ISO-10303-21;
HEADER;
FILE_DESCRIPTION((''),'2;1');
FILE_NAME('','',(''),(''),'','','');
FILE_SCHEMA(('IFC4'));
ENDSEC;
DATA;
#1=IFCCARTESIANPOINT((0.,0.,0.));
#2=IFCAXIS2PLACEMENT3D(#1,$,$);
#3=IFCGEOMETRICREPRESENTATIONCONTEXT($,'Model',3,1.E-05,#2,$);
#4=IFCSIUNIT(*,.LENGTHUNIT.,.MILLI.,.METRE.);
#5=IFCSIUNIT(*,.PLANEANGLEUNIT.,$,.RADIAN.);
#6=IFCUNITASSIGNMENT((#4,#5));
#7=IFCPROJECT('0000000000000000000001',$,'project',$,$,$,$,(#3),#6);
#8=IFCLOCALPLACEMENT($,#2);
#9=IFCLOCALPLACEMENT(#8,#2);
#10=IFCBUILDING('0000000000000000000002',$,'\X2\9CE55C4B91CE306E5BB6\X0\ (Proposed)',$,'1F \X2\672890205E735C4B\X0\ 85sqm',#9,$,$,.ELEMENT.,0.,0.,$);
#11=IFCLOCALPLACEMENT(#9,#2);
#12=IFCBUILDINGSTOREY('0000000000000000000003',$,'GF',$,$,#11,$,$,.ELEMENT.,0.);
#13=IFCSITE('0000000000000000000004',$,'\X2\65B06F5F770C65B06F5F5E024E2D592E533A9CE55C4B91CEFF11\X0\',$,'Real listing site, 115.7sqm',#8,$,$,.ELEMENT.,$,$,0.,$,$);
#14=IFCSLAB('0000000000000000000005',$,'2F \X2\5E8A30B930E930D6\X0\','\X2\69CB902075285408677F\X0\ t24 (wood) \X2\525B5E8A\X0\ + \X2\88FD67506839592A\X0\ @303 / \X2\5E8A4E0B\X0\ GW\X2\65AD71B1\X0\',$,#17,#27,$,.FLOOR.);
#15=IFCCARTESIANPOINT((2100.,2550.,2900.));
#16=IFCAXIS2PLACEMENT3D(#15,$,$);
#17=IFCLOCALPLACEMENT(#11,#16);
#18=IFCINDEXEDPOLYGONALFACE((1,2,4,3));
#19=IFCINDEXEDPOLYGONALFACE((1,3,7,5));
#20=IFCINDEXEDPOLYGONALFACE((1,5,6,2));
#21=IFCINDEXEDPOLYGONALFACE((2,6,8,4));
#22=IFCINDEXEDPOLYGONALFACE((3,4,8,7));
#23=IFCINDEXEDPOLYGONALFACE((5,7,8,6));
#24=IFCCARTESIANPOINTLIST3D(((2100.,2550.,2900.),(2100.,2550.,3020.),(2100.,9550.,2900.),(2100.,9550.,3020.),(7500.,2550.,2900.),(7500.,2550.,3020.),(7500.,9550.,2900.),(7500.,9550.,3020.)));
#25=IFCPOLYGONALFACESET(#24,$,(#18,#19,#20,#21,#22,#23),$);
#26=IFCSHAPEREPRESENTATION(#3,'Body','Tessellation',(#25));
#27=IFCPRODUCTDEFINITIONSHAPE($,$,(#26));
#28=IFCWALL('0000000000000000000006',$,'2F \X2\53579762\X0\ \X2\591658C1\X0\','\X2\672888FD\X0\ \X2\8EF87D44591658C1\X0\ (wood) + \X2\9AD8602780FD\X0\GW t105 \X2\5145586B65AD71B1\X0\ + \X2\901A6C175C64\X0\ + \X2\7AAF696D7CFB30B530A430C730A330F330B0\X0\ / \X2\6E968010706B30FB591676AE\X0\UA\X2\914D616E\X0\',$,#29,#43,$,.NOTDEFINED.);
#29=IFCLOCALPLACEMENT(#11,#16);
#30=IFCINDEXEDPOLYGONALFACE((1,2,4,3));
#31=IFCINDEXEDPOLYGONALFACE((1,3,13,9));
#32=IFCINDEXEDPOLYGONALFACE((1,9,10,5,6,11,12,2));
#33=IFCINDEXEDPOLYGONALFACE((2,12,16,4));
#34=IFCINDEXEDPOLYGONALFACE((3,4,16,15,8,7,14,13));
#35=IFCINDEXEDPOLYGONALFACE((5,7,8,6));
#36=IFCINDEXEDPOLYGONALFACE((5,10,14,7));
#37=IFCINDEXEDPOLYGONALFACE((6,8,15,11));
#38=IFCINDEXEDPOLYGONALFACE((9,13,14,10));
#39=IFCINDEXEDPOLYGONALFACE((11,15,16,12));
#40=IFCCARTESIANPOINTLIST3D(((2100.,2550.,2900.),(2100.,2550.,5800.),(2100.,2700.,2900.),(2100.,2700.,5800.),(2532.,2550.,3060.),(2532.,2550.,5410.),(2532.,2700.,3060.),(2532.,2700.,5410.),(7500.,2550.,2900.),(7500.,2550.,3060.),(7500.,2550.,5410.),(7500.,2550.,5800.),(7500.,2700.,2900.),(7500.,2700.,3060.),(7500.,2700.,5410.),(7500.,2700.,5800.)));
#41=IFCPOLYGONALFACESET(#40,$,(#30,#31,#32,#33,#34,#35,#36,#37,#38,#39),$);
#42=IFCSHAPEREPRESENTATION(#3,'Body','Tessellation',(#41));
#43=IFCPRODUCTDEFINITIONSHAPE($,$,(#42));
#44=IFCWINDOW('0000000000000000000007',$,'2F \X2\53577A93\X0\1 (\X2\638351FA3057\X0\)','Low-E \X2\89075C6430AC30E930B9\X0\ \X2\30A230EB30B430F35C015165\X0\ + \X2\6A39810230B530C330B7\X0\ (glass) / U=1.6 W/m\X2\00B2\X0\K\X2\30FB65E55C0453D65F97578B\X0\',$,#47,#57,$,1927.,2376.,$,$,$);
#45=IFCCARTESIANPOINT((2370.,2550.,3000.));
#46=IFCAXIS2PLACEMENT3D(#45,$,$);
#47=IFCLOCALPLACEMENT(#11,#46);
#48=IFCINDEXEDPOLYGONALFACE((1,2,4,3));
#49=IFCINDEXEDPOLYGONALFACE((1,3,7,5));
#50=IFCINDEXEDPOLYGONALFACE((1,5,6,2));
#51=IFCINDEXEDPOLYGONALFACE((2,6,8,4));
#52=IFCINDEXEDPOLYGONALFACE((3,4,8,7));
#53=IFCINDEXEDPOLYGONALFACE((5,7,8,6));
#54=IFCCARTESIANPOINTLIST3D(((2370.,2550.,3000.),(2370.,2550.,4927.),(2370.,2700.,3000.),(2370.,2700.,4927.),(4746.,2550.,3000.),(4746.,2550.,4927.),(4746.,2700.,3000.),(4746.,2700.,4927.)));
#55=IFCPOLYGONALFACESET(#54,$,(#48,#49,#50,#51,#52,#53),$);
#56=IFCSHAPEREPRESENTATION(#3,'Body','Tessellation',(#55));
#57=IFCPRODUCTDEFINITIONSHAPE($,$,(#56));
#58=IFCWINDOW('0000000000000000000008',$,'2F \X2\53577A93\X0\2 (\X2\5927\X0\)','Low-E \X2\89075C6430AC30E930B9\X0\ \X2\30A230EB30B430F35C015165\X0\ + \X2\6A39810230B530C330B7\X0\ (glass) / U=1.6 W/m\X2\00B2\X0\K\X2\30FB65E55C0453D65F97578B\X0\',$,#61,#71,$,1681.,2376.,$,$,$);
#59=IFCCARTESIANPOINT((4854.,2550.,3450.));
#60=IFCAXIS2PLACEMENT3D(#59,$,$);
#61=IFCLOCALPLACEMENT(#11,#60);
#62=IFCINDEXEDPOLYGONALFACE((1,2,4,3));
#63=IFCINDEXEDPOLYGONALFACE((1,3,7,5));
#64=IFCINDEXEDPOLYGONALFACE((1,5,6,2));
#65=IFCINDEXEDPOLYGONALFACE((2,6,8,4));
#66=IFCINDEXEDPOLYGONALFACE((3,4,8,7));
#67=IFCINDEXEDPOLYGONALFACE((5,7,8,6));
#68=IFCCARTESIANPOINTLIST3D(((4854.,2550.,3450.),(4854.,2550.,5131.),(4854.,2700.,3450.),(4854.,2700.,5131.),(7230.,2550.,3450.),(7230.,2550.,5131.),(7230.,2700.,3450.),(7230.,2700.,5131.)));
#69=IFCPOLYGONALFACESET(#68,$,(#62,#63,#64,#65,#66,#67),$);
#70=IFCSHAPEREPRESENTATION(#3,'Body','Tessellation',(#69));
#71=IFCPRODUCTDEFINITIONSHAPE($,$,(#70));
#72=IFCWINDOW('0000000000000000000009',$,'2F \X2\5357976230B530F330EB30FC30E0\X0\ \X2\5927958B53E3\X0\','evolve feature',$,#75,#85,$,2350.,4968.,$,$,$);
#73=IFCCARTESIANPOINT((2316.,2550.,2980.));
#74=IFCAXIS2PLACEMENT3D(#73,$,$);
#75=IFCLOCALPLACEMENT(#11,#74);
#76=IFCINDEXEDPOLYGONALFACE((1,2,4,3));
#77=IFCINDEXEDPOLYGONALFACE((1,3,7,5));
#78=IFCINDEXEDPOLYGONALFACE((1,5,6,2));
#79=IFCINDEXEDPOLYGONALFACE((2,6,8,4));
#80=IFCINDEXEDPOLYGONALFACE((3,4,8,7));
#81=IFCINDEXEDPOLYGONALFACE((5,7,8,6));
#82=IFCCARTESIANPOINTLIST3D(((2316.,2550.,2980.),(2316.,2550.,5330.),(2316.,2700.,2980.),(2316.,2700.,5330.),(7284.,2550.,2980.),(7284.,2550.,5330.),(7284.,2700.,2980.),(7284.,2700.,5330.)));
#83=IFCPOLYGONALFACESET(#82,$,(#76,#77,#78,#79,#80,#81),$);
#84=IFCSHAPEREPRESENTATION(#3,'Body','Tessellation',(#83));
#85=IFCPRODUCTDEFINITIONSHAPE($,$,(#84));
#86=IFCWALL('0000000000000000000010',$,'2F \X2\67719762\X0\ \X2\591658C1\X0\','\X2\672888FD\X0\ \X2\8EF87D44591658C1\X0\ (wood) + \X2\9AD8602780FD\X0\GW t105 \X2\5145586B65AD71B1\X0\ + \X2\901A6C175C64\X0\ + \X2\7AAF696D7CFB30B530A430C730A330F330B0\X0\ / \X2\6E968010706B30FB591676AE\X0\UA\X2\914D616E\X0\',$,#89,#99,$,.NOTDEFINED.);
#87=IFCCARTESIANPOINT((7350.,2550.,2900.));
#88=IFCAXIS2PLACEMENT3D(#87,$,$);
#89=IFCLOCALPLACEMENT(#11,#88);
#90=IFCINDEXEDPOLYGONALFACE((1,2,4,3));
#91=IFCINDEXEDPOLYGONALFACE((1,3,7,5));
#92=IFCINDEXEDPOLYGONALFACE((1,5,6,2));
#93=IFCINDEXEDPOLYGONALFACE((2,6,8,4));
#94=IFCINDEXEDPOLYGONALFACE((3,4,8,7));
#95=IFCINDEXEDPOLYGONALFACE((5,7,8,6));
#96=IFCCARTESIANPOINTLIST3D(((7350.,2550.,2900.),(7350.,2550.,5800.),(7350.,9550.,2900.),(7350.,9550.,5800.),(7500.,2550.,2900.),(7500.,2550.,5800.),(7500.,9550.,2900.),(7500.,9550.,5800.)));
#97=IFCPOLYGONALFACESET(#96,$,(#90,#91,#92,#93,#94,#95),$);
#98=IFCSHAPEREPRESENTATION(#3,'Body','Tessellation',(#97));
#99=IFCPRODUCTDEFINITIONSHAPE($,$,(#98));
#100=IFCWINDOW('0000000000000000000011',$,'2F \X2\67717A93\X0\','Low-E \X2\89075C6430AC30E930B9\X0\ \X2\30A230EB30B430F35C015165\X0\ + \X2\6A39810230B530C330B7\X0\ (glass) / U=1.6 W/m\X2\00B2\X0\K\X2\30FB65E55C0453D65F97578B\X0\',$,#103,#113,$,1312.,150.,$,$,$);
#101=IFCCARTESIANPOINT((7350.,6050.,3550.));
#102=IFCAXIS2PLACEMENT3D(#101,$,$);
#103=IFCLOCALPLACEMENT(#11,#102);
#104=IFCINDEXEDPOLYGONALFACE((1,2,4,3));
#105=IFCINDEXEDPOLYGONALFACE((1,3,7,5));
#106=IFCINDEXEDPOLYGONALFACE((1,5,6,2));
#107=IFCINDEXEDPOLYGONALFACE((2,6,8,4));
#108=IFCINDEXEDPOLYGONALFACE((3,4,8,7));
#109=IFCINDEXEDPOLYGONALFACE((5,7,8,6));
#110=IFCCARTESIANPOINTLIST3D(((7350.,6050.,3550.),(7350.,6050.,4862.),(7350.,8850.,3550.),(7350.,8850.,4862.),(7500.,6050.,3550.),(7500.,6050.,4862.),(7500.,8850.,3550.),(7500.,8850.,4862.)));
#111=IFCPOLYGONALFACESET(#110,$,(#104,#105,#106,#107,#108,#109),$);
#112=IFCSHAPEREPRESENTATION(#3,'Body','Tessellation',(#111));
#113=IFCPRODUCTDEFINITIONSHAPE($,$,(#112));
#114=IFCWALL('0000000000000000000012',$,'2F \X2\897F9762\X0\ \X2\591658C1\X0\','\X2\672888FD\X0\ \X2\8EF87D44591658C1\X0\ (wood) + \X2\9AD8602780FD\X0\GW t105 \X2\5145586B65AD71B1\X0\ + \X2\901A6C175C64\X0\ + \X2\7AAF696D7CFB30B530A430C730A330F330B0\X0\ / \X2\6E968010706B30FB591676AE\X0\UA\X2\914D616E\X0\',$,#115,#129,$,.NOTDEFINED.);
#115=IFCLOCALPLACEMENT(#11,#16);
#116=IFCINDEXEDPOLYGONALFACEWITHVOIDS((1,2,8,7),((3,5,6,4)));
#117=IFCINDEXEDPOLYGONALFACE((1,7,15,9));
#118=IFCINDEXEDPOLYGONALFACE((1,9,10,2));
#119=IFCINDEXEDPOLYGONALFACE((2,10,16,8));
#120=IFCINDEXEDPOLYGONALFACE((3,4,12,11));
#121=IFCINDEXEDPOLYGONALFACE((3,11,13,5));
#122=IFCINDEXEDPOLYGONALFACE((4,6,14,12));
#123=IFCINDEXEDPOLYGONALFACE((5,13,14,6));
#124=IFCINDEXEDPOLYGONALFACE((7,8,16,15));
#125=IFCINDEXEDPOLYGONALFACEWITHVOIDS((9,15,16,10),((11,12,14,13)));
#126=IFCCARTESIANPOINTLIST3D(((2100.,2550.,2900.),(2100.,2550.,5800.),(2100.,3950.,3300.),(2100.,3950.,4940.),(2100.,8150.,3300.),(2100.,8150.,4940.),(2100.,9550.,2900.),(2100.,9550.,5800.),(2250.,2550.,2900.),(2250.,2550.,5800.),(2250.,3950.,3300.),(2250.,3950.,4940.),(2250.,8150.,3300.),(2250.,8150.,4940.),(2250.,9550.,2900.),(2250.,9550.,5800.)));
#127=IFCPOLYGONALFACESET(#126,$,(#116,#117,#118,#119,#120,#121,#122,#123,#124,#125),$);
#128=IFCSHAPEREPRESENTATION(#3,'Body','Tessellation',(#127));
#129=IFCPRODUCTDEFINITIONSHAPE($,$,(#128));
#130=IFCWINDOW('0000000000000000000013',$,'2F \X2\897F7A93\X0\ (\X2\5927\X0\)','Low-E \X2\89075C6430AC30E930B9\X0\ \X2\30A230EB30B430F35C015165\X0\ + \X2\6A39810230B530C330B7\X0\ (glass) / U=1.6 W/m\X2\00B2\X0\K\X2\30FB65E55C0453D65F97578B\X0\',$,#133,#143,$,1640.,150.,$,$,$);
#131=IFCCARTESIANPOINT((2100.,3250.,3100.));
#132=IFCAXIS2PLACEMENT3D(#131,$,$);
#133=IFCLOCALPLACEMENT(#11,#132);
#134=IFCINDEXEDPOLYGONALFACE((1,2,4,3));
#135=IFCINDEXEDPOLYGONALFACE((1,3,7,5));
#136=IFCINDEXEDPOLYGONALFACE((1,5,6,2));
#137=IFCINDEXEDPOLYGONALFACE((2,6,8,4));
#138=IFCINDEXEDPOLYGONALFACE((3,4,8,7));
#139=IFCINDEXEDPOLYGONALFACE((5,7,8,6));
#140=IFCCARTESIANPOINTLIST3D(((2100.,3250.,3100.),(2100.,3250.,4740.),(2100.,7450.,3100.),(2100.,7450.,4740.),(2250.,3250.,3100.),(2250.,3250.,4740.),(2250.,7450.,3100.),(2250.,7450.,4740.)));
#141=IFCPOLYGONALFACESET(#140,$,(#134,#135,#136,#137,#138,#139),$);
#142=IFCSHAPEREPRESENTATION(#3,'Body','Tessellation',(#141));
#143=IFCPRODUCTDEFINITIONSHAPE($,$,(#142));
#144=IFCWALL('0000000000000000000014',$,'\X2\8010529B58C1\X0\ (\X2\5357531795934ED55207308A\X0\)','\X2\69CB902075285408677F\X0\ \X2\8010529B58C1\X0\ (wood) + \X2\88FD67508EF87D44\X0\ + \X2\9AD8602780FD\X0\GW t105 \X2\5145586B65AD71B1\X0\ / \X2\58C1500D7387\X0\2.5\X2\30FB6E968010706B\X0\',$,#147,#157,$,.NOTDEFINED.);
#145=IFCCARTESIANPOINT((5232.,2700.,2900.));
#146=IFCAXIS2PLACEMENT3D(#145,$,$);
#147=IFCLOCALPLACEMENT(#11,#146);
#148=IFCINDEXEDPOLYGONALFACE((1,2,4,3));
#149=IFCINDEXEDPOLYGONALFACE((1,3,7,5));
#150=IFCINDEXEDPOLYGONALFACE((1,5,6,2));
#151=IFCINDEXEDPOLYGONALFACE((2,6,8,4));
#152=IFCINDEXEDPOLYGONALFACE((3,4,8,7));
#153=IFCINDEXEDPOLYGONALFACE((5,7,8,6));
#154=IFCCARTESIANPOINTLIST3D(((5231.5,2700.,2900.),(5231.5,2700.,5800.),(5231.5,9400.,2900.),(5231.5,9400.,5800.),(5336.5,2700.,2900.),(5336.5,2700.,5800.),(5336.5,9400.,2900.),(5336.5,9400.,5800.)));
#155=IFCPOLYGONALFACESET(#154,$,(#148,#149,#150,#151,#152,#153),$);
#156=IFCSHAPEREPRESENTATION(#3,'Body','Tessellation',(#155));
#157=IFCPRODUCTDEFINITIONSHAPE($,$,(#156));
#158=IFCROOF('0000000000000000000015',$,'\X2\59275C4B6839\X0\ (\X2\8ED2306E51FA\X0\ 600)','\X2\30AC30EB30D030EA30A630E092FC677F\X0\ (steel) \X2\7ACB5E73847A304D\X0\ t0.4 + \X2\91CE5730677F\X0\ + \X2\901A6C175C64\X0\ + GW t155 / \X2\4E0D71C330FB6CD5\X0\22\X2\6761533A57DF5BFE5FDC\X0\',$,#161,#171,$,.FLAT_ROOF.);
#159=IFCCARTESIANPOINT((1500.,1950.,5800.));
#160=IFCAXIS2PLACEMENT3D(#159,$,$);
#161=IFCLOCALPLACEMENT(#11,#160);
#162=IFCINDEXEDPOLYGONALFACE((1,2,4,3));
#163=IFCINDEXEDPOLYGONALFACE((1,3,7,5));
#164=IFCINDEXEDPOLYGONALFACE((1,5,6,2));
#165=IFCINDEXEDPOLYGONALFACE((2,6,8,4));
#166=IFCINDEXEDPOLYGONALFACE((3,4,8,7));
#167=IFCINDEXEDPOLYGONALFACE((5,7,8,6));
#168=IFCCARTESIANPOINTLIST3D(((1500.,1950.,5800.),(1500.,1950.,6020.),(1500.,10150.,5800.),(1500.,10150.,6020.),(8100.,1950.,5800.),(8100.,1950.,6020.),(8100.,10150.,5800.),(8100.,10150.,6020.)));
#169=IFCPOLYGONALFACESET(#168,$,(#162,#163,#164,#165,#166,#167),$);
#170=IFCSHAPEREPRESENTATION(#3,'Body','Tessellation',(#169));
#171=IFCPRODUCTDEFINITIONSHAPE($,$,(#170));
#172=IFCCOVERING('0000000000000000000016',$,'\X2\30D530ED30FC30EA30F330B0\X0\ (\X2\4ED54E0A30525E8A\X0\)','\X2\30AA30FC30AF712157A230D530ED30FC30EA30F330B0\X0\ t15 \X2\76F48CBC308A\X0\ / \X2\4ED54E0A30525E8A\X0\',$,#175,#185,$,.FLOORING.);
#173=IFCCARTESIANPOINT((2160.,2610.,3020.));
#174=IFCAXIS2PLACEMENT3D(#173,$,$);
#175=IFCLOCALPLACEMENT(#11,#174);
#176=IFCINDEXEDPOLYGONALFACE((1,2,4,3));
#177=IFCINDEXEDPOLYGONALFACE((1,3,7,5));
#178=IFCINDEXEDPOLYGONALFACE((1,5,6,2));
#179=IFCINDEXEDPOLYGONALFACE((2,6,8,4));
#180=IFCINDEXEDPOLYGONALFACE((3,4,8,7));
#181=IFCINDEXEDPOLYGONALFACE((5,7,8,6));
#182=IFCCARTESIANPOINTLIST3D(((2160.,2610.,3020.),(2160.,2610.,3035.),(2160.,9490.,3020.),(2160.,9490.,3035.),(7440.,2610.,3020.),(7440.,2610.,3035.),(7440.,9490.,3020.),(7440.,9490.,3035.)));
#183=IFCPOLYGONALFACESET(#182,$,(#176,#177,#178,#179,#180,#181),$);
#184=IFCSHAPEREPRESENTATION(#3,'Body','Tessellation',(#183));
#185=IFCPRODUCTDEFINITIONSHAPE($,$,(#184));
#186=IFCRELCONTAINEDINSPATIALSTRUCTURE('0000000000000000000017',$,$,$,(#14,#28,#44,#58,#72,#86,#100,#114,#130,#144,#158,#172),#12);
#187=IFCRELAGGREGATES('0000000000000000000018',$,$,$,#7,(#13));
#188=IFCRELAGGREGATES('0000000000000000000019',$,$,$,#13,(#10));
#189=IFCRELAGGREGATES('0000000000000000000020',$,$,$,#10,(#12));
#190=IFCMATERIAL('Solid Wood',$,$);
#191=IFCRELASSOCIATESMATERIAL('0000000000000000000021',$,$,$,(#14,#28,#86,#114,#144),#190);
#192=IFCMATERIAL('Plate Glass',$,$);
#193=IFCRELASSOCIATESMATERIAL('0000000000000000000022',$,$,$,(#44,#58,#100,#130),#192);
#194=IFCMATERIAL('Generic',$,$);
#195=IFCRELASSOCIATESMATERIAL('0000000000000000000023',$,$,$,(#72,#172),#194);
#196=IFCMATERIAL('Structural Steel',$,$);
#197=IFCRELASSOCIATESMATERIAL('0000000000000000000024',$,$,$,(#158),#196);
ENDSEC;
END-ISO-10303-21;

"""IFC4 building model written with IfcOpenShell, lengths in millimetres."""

from ifc_helpers import new_model, si_unit, frame, frame_2d, origin, place, context, project, spatial, rectangle, extrude, material, element, fill, save


model = new_model("IFC4")

# Units and contexts
model_context = context("Model", 3, precision=1e-05, world=origin())
ifc_project = project(units=[si_unit("LENGTHUNIT", "METRE", prefix="MILLI"), si_unit("PLANEANGLEUNIT", "RADIAN")], contexts=[model_context])

# Site, building, storey
site_placement = place(None, origin())
site = spatial("IfcSite", under=ifc_project, at=site_placement, Name="新潟県新潟市中央区鳥屋野１", ObjectType="Real listing site, 115.7sqm", CompositionType="ELEMENT", RefElevation=0.0)
building_placement = place(site_placement, origin())
building = spatial("IfcBuilding", under=site, at=building_placement, Name="鳥屋野の家 (Proposed)", ObjectType="1F 木造平屋 85sqm", CompositionType="ELEMENT", ElevationOfRefHeight=0.0, ElevationOfTerrain=0.0)
storey_placement = place(building_placement, origin())
storey = spatial("IfcBuildingStorey", under=building, at=storey_placement, Name="GF", CompositionType="ELEMENT", Elevation=0.0)

# Slab
ifc_material_1 = material(Name="Solid Wood")
slab_placement = place(storey_placement, frame((2100.0, 2550.0, 2900.0)))
element("IfcSlab", 1, at=slab_placement, inside=storey, material=ifc_material_1, Name="2F 床スラブ", Description="構造用合板 t24 (wood) 剛床 + 製材根太 @303 / 床下 GW断熱", PredefinedType="FLOOR", context=model_context, shape_type="SweptSolid", body=[
    extrude(rectangle(XDim=5400.0, YDim=7000.0, at=frame_2d((2700.0, 3500.0))), frame((2100.0, 2550.0, 2900.0)), (0.0, 0.0, 1.0), 120.0),
])

# Wall, openings, windows
wall_1_placement = place(storey_placement, frame((2100.0, 2550.0, 2900.0)))
wall_1 = element("IfcWall", 2, at=wall_1_placement, inside=storey, material=ifc_material_1, Name="2F 南面 外壁", Description="木製 軸組外壁 (wood) + 高性能GW t105 充填断熱 + 通気層 + 窯業系サイディング / 準耐火・外皮UA配慮", PredefinedType="NOTDEFINED", context=model_context, shape_type="SweptSolid", body=[
    extrude(rectangle(XDim=5400.0, YDim=150.0, at=frame_2d((2700.0, 75.0))), frame((2100.0, 2550.0, 2900.0)), (0.0, 0.0, 1.0), 2900.0),
])
opening_1_placement = place(storey_placement, frame((2370.0, 2550.0, 3000.0)))
opening_1 = element("IfcOpeningElement", 3, at=opening_1_placement, cuts=wall_1, PredefinedType="NOTDEFINED", context=model_context, shape_type="SweptSolid", body=[
    extrude(rectangle(XDim=2376.0, YDim=150.0, at=frame_2d((1188.0, 75.0))), frame((2370.0, 2550.0, 3000.0)), (0.0, 0.0, 1.0), 1927.0),
])
opening_2_placement = place(storey_placement, frame((4854.0, 2550.0, 3450.0)))
opening_2 = element("IfcOpeningElement", 4, at=opening_2_placement, cuts=wall_1, PredefinedType="NOTDEFINED", context=model_context, shape_type="SweptSolid", body=[
    extrude(rectangle(XDim=2376.0, YDim=150.0, at=frame_2d((1188.0, 75.0))), frame((4854.0, 2550.0, 3450.0)), (0.0, 0.0, 1.0), 1681.0),
])
opening_3_placement = place(storey_placement, frame((2316.0, 2550.0, 2980.0)))
opening_3 = element("IfcOpeningElement", 5, at=opening_3_placement, cuts=wall_1, PredefinedType="NOTDEFINED", context=model_context, shape_type="SweptSolid", body=[
    extrude(rectangle(XDim=4968.0, YDim=150.0, at=frame_2d((2484.0, 75.0))), frame((2316.0, 2550.0, 2980.0)), (0.0, 0.0, 1.0), 2350.0),
])
ifc_material_2 = material(Name="Plate Glass")
window_1_placement = place(storey_placement, frame((2370.0, 2550.0, 3000.0)))
window_1 = element("IfcWindow", 6, at=window_1_placement, inside=storey, material=ifc_material_2, Name="2F 南窓1 (掃出し)", Description="Low-E 複層ガラス アルゴン封入 + 樹脂サッシ (glass) / U=1.6 W/m²K・日射取得型", OverallHeight=1927.0, OverallWidth=2376.0, context=model_context, shape_type="SweptSolid", body=[
    extrude(rectangle(XDim=2376.0, YDim=150.0, at=frame_2d((1188.0, 75.0))), frame((2370.0, 2550.0, 3000.0)), (0.0, 0.0, 1.0), 1927.0),
])
fill(opening_1, window_1)
window_2_placement = place(storey_placement, frame((4854.0, 2550.0, 3450.0)))
window_2 = element("IfcWindow", 7, at=window_2_placement, inside=storey, material=ifc_material_2, Name="2F 南窓2 (大)", Description="Low-E 複層ガラス アルゴン封入 + 樹脂サッシ (glass) / U=1.6 W/m²K・日射取得型", OverallHeight=1681.0, OverallWidth=2376.0, context=model_context, shape_type="SweptSolid", body=[
    extrude(rectangle(XDim=2376.0, YDim=150.0, at=frame_2d((1188.0, 75.0))), frame((4854.0, 2550.0, 3450.0)), (0.0, 0.0, 1.0), 1681.0),
])
fill(opening_2, window_2)
ifc_material_3 = material(Name="Generic")
window_3_placement = place(storey_placement, frame((2316.0, 2550.0, 2980.0)))
window_3 = element("IfcWindow", 8, at=window_3_placement, inside=storey, material=ifc_material_3, Name="2F 南面サンルーム 大開口", Description="evolve feature", OverallHeight=2350.0, OverallWidth=4968.0, context=model_context, shape_type="SweptSolid", body=[
    extrude(rectangle(XDim=4968.0, YDim=150.0, at=frame_2d((2484.0, 75.0))), frame((2316.0, 2550.0, 2980.0)), (0.0, 0.0, 1.0), 2350.0),
])
fill(opening_3, window_3)

# Walls, openings, windows
wall_2_placement = place(storey_placement, frame((7350.0, 2550.0, 2900.0)))
wall_2 = element("IfcWall", 9, at=wall_2_placement, inside=storey, material=ifc_material_1, Name="2F 東面 外壁", Description="木製 軸組外壁 (wood) + 高性能GW t105 充填断熱 + 通気層 + 窯業系サイディング / 準耐火・外皮UA配慮", PredefinedType="NOTDEFINED", context=model_context, shape_type="SweptSolid", body=[
    extrude(rectangle(XDim=150.0, YDim=7000.0, at=frame_2d((75.0, 3500.0))), frame((7350.0, 2550.0, 2900.0)), (0.0, 0.0, 1.0), 2900.0),
])
opening_4_placement = place(storey_placement, frame((7350.0, 6050.0, 3550.0)))
opening_4 = element("IfcOpeningElement", 10, at=opening_4_placement, cuts=wall_2, PredefinedType="NOTDEFINED", context=model_context, shape_type="SweptSolid", body=[
    extrude(rectangle(XDim=150.0, YDim=2800.0, at=frame_2d((75.0, 1400.0))), frame((7350.0, 6050.0, 3550.0)), (0.0, 0.0, 1.0), 1312.0),
])
window_4_placement = place(storey_placement, frame((7350.0, 6050.0, 3550.0)))
window_4 = element("IfcWindow", 11, at=window_4_placement, inside=storey, material=ifc_material_2, Name="2F 東窓", Description="Low-E 複層ガラス アルゴン封入 + 樹脂サッシ (glass) / U=1.6 W/m²K・日射取得型", OverallHeight=1312.0, OverallWidth=150.0, context=model_context, shape_type="SweptSolid", body=[
    extrude(rectangle(XDim=150.0, YDim=2800.0, at=frame_2d((75.0, 1400.0))), frame((7350.0, 6050.0, 3550.0)), (0.0, 0.0, 1.0), 1312.0),
])
fill(opening_4, window_4)
wall_3_placement = place(storey_placement, frame((2100.0, 2550.0, 2900.0)))
wall_3 = element("IfcWall", 12, at=wall_3_placement, inside=storey, material=ifc_material_1, Name="2F 西面 外壁", Description="木製 軸組外壁 (wood) + 高性能GW t105 充填断熱 + 通気層 + 窯業系サイディング / 準耐火・外皮UA配慮", PredefinedType="NOTDEFINED", context=model_context, shape_type="SweptSolid", body=[
    extrude(rectangle(XDim=150.0, YDim=7000.0, at=frame_2d((75.0, 3500.0))), frame((2100.0, 2550.0, 2900.0)), (0.0, 0.0, 1.0), 2900.0),
])
opening_5_placement = place(storey_placement, frame((2100.0, 3250.0, 3100.0)))
opening_5 = element("IfcOpeningElement", 13, at=opening_5_placement, cuts=wall_3, PredefinedType="NOTDEFINED", context=model_context, shape_type="SweptSolid", body=[
    extrude(rectangle(XDim=150.0, YDim=4200.0, at=frame_2d((75.0, 2100.0))), frame((2100.0, 3250.0, 3100.0)), (0.0, 0.0, 1.0), 1640.0),
])
window_5_placement = place(storey_placement, frame((2100.0, 3250.0, 3100.0)))
window_5 = element("IfcWindow", 14, at=window_5_placement, inside=storey, material=ifc_material_2, Name="2F 西窓 (大)", Description="Low-E 複層ガラス アルゴン封入 + 樹脂サッシ (glass) / U=1.6 W/m²K・日射取得型", OverallHeight=1640.0, OverallWidth=150.0, context=model_context, shape_type="SweptSolid", body=[
    extrude(rectangle(XDim=150.0, YDim=4200.0, at=frame_2d((75.0, 2100.0))), frame((2100.0, 3250.0, 3100.0)), (0.0, 0.0, 1.0), 1640.0),
])
fill(opening_5, window_5)

# Wall
wall_4_placement = place(storey_placement, frame((5232.0, 2700.0, 2900.0)))
element("IfcWall", 15, at=wall_4_placement, inside=storey, material=ifc_material_1, Name="耐力壁 (南北間仕切り)", Description="構造用合板 耐力壁 (wood) + 製材軸組 + 高性能GW t105 充填断熱 / 壁倍率2.5・準耐火", PredefinedType="NOTDEFINED", context=model_context, shape_type="SweptSolid", body=[
    extrude(rectangle(XDim=105.0, YDim=6700.0, at=frame_2d((52.0, 3350.0))), frame((5232.0, 2700.0, 2900.0)), (0.0, 0.0, 1.0), 2900.0),
])

# Roof
ifc_material_4 = material(Name="Structural Steel")
roof_placement = place(storey_placement, frame((1500.0, 1950.0, 5800.0)))
element("IfcRoof", 16, at=roof_placement, inside=storey, material=ifc_material_4, Name="大屋根 (軒の出 600)", Description="ガルバリウム鋼板 (steel) 立平葺き t0.4 + 野地板 + 通気層 + GW t155 / 不燃・法22条区域対応", PredefinedType="FLAT_ROOF", context=model_context, shape_type="SweptSolid", body=[
    extrude(rectangle(XDim=6600.0, YDim=8200.0, at=frame_2d((3300.0, 4100.0))), frame((1500.0, 1950.0, 5800.0)), (0.0, 0.0, 1.0), 220.0),
])

# Covering
covering_placement = place(storey_placement, frame((2160.0, 2610.0, 3020.0)))
element("IfcCovering", 17, at=covering_placement, inside=storey, material=ifc_material_3, Name="フローリング (仕上げ床)", Description="オーク無垢フローリング t15 直貼り / 仕上げ床", PredefinedType="FLOORING", context=model_context, shape_type="SweptSolid", body=[
    extrude(rectangle(XDim=5280.0, YDim=6880.0, at=frame_2d((2640.0, 3440.0))), frame((2160.0, 2610.0, 3020.0)), (0.0, 0.0, 1.0), 15.0),
])

save(model, "model.ifc")
